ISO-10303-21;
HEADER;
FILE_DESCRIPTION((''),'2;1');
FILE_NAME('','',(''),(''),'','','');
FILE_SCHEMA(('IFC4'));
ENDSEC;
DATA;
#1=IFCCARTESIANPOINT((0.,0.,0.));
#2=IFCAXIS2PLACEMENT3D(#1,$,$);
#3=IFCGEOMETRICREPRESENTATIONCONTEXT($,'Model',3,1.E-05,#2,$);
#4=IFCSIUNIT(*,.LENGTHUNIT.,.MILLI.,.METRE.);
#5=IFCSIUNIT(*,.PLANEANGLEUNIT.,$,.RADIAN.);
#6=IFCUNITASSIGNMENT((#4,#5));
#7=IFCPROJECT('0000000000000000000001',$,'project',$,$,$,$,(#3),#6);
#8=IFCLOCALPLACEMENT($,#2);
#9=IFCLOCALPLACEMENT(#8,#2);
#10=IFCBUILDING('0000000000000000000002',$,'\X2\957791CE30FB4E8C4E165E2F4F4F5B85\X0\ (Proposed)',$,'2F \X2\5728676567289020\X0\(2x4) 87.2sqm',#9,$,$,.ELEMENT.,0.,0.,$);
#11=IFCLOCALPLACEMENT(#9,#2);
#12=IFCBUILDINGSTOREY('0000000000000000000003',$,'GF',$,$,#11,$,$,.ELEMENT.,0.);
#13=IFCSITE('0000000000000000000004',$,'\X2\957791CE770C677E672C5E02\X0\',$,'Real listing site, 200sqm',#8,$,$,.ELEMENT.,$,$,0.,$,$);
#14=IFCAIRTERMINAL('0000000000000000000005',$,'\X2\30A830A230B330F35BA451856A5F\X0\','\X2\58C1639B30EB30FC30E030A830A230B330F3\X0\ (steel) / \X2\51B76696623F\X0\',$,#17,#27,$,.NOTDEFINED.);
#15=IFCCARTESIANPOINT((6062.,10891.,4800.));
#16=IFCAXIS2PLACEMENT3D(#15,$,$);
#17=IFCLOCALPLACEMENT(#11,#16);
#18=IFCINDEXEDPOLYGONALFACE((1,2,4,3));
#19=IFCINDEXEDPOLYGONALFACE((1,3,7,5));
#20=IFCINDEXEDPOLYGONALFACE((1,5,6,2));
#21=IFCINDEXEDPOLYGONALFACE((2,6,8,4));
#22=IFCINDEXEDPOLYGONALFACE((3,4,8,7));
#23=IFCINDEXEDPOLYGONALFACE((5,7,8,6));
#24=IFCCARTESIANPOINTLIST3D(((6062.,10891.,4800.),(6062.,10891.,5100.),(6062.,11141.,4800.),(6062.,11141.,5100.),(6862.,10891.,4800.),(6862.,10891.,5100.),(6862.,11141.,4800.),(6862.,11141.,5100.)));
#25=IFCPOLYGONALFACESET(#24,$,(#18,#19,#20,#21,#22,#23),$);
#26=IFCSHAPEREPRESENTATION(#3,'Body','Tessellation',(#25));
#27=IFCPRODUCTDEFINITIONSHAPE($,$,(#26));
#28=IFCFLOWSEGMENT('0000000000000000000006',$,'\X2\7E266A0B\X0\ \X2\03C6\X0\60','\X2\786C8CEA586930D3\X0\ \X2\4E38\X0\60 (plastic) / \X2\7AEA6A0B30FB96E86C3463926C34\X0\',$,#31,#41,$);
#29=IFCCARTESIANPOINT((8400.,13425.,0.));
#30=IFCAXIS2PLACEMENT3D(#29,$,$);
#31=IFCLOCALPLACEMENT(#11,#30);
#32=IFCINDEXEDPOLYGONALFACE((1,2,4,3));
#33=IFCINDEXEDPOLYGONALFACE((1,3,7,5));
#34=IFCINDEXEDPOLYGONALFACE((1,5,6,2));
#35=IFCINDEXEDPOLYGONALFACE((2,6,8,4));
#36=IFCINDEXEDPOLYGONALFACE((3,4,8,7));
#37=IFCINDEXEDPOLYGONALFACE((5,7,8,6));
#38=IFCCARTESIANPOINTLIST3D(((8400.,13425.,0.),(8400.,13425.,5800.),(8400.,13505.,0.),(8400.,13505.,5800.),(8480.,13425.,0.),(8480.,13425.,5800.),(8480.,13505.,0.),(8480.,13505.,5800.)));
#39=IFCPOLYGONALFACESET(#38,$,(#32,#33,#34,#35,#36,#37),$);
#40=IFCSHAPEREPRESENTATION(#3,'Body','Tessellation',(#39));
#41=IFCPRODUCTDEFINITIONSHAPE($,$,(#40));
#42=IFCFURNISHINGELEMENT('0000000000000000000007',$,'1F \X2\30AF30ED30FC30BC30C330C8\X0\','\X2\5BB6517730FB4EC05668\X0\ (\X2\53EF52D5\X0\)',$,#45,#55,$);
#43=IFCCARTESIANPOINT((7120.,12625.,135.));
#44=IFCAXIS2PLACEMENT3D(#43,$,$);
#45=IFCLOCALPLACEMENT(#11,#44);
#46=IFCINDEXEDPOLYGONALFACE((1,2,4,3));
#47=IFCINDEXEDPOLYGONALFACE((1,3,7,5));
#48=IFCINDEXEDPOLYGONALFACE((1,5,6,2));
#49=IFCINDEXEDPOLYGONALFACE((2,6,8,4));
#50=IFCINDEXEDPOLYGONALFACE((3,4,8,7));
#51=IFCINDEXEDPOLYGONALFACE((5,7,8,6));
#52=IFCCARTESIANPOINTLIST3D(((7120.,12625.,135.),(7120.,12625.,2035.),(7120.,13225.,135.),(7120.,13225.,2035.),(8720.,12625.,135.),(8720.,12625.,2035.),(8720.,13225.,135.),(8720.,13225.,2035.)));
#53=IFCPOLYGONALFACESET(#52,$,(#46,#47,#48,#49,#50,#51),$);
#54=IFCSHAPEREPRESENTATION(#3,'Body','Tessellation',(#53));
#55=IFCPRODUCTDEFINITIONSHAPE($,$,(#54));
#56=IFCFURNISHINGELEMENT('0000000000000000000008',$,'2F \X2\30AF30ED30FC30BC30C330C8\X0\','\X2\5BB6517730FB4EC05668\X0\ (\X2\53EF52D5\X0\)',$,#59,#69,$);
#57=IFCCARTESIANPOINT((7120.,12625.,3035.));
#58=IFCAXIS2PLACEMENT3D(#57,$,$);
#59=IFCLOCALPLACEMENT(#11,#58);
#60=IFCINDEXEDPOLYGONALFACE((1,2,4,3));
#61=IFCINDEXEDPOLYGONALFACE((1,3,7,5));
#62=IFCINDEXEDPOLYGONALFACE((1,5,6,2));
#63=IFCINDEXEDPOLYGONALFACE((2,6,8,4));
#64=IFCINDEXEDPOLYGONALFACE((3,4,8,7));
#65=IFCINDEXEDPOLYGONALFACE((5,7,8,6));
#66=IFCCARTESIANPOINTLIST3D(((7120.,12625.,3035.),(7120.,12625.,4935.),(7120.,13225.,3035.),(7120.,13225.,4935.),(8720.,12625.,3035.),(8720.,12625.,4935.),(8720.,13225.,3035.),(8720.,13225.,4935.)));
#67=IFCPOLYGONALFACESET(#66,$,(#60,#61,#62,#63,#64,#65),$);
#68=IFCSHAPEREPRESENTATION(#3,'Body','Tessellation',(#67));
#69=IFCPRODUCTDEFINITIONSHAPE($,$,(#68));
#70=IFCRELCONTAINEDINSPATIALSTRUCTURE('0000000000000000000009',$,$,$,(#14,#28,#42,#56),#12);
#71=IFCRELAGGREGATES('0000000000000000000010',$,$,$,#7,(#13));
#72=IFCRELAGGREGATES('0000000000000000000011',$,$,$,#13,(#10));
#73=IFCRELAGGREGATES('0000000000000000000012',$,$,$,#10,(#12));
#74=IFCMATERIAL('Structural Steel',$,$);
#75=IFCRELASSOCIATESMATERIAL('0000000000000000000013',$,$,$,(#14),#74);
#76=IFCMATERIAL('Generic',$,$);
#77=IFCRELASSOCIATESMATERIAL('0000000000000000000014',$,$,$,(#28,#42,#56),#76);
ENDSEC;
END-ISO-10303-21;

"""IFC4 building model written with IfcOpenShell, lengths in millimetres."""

from ifc_helpers import new_model, si_unit, frame, frame_2d, origin, place, context, project, spatial, rectangle, extrude, material, element, save


model = new_model("IFC4")

# Units and contexts
model_context = context("Model", 3, precision=1e-05, world=origin())
ifc_project = project(units=[si_unit("LENGTHUNIT", "METRE", prefix="MILLI"), si_unit("PLANEANGLEUNIT", "RADIAN")], contexts=[model_context])

# Site, building, storey
site_placement = place(None, origin())
site = spatial("IfcSite", under=ifc_project, at=site_placement, Name="長野県松本市", ObjectType="Real listing site, 200sqm", CompositionType="ELEMENT", RefElevation=0.0)
building_placement = place(site_placement, origin())
building = spatial("IfcBuilding", under=site, at=building_placement, Name="長野・二世帯住宅 (Proposed)", ObjectType="2F 在来木造(2x4) 87.2sqm", CompositionType="ELEMENT", ElevationOfRefHeight=0.0, ElevationOfTerrain=0.0)
storey_placement = place(building_placement, origin())
storey = spatial("IfcBuildingStorey", under=building, at=storey_placement, Name="GF", CompositionType="ELEMENT", Elevation=0.0)

# Shared definitions
ifc_material_1 = material(Name="Generic")

# Shared definitions
ifc_material_2 = material(Name="Structural Steel")

# Air terminal
air_terminal_placement = place(storey_placement, frame((6062.0, 10891.0, 4800.0)))
element("IfcAirTerminal", 1, at=air_terminal_placement, inside=storey, material=ifc_material_2, Name="エアコン室内機", Description="壁掛ルームエアコン (steel) / 冷暖房", PredefinedType="NOTDEFINED", context=model_context, shape_type="SweptSolid", body=[
    extrude(rectangle(XDim=800.0, YDim=250.0, at=frame_2d((400.0, 125.0))), frame((6062.0, 10891.0, 4800.0)), (0.0, 0.0, 1.0), 300.0),
])

# Flow segment
flow_segment_placement = place(storey_placement, frame((8400.0, 13425.0, 0.0)))
element("IfcFlowSegment", 2, at=flow_segment_placement, inside=storey, material=ifc_material_1, Name="縦樋 φ60", Description="硬質塩ビ 丸60 (plastic) / 竪樋・雨水排水", context=model_context, shape_type="SweptSolid", body=[
    extrude(rectangle(XDim=80.0, YDim=80.0, at=frame_2d((40.0, 40.0))), frame((8400.0, 13425.0, 0.0)), (0.0, 0.0, 1.0), 5800.0),
])

# Furnishing elements
furnishing_1_placement = place(storey_placement, frame((7120.0, 12625.0, 135.0)))
element("IfcFurnishingElement", 3, at=furnishing_1_placement, inside=storey, material=ifc_material_1, Name="1F クローゼット", Description="家具・什器 (可動)", context=model_context, shape_type="SweptSolid", body=[
    extrude(rectangle(XDim=1600.0, YDim=600.0, at=frame_2d((800.0, 300.0))), frame((7120.0, 12625.0, 135.0)), (0.0, 0.0, 1.0), 1900.0),
])
furnishing_2_placement = place(storey_placement, frame((7120.0, 12625.0, 3035.0)))
element("IfcFurnishingElement", 4, at=furnishing_2_placement, inside=storey, material=ifc_material_1, Name="2F クローゼット", Description="家具・什器 (可動)", context=model_context, shape_type="SweptSolid", body=[
    extrude(rectangle(XDim=1600.0, YDim=600.0, at=frame_2d((800.0, 300.0))), frame((7120.0, 12625.0, 3035.0)), (0.0, 0.0, 1.0), 1900.0),
])

save(model, "model.ifc")
